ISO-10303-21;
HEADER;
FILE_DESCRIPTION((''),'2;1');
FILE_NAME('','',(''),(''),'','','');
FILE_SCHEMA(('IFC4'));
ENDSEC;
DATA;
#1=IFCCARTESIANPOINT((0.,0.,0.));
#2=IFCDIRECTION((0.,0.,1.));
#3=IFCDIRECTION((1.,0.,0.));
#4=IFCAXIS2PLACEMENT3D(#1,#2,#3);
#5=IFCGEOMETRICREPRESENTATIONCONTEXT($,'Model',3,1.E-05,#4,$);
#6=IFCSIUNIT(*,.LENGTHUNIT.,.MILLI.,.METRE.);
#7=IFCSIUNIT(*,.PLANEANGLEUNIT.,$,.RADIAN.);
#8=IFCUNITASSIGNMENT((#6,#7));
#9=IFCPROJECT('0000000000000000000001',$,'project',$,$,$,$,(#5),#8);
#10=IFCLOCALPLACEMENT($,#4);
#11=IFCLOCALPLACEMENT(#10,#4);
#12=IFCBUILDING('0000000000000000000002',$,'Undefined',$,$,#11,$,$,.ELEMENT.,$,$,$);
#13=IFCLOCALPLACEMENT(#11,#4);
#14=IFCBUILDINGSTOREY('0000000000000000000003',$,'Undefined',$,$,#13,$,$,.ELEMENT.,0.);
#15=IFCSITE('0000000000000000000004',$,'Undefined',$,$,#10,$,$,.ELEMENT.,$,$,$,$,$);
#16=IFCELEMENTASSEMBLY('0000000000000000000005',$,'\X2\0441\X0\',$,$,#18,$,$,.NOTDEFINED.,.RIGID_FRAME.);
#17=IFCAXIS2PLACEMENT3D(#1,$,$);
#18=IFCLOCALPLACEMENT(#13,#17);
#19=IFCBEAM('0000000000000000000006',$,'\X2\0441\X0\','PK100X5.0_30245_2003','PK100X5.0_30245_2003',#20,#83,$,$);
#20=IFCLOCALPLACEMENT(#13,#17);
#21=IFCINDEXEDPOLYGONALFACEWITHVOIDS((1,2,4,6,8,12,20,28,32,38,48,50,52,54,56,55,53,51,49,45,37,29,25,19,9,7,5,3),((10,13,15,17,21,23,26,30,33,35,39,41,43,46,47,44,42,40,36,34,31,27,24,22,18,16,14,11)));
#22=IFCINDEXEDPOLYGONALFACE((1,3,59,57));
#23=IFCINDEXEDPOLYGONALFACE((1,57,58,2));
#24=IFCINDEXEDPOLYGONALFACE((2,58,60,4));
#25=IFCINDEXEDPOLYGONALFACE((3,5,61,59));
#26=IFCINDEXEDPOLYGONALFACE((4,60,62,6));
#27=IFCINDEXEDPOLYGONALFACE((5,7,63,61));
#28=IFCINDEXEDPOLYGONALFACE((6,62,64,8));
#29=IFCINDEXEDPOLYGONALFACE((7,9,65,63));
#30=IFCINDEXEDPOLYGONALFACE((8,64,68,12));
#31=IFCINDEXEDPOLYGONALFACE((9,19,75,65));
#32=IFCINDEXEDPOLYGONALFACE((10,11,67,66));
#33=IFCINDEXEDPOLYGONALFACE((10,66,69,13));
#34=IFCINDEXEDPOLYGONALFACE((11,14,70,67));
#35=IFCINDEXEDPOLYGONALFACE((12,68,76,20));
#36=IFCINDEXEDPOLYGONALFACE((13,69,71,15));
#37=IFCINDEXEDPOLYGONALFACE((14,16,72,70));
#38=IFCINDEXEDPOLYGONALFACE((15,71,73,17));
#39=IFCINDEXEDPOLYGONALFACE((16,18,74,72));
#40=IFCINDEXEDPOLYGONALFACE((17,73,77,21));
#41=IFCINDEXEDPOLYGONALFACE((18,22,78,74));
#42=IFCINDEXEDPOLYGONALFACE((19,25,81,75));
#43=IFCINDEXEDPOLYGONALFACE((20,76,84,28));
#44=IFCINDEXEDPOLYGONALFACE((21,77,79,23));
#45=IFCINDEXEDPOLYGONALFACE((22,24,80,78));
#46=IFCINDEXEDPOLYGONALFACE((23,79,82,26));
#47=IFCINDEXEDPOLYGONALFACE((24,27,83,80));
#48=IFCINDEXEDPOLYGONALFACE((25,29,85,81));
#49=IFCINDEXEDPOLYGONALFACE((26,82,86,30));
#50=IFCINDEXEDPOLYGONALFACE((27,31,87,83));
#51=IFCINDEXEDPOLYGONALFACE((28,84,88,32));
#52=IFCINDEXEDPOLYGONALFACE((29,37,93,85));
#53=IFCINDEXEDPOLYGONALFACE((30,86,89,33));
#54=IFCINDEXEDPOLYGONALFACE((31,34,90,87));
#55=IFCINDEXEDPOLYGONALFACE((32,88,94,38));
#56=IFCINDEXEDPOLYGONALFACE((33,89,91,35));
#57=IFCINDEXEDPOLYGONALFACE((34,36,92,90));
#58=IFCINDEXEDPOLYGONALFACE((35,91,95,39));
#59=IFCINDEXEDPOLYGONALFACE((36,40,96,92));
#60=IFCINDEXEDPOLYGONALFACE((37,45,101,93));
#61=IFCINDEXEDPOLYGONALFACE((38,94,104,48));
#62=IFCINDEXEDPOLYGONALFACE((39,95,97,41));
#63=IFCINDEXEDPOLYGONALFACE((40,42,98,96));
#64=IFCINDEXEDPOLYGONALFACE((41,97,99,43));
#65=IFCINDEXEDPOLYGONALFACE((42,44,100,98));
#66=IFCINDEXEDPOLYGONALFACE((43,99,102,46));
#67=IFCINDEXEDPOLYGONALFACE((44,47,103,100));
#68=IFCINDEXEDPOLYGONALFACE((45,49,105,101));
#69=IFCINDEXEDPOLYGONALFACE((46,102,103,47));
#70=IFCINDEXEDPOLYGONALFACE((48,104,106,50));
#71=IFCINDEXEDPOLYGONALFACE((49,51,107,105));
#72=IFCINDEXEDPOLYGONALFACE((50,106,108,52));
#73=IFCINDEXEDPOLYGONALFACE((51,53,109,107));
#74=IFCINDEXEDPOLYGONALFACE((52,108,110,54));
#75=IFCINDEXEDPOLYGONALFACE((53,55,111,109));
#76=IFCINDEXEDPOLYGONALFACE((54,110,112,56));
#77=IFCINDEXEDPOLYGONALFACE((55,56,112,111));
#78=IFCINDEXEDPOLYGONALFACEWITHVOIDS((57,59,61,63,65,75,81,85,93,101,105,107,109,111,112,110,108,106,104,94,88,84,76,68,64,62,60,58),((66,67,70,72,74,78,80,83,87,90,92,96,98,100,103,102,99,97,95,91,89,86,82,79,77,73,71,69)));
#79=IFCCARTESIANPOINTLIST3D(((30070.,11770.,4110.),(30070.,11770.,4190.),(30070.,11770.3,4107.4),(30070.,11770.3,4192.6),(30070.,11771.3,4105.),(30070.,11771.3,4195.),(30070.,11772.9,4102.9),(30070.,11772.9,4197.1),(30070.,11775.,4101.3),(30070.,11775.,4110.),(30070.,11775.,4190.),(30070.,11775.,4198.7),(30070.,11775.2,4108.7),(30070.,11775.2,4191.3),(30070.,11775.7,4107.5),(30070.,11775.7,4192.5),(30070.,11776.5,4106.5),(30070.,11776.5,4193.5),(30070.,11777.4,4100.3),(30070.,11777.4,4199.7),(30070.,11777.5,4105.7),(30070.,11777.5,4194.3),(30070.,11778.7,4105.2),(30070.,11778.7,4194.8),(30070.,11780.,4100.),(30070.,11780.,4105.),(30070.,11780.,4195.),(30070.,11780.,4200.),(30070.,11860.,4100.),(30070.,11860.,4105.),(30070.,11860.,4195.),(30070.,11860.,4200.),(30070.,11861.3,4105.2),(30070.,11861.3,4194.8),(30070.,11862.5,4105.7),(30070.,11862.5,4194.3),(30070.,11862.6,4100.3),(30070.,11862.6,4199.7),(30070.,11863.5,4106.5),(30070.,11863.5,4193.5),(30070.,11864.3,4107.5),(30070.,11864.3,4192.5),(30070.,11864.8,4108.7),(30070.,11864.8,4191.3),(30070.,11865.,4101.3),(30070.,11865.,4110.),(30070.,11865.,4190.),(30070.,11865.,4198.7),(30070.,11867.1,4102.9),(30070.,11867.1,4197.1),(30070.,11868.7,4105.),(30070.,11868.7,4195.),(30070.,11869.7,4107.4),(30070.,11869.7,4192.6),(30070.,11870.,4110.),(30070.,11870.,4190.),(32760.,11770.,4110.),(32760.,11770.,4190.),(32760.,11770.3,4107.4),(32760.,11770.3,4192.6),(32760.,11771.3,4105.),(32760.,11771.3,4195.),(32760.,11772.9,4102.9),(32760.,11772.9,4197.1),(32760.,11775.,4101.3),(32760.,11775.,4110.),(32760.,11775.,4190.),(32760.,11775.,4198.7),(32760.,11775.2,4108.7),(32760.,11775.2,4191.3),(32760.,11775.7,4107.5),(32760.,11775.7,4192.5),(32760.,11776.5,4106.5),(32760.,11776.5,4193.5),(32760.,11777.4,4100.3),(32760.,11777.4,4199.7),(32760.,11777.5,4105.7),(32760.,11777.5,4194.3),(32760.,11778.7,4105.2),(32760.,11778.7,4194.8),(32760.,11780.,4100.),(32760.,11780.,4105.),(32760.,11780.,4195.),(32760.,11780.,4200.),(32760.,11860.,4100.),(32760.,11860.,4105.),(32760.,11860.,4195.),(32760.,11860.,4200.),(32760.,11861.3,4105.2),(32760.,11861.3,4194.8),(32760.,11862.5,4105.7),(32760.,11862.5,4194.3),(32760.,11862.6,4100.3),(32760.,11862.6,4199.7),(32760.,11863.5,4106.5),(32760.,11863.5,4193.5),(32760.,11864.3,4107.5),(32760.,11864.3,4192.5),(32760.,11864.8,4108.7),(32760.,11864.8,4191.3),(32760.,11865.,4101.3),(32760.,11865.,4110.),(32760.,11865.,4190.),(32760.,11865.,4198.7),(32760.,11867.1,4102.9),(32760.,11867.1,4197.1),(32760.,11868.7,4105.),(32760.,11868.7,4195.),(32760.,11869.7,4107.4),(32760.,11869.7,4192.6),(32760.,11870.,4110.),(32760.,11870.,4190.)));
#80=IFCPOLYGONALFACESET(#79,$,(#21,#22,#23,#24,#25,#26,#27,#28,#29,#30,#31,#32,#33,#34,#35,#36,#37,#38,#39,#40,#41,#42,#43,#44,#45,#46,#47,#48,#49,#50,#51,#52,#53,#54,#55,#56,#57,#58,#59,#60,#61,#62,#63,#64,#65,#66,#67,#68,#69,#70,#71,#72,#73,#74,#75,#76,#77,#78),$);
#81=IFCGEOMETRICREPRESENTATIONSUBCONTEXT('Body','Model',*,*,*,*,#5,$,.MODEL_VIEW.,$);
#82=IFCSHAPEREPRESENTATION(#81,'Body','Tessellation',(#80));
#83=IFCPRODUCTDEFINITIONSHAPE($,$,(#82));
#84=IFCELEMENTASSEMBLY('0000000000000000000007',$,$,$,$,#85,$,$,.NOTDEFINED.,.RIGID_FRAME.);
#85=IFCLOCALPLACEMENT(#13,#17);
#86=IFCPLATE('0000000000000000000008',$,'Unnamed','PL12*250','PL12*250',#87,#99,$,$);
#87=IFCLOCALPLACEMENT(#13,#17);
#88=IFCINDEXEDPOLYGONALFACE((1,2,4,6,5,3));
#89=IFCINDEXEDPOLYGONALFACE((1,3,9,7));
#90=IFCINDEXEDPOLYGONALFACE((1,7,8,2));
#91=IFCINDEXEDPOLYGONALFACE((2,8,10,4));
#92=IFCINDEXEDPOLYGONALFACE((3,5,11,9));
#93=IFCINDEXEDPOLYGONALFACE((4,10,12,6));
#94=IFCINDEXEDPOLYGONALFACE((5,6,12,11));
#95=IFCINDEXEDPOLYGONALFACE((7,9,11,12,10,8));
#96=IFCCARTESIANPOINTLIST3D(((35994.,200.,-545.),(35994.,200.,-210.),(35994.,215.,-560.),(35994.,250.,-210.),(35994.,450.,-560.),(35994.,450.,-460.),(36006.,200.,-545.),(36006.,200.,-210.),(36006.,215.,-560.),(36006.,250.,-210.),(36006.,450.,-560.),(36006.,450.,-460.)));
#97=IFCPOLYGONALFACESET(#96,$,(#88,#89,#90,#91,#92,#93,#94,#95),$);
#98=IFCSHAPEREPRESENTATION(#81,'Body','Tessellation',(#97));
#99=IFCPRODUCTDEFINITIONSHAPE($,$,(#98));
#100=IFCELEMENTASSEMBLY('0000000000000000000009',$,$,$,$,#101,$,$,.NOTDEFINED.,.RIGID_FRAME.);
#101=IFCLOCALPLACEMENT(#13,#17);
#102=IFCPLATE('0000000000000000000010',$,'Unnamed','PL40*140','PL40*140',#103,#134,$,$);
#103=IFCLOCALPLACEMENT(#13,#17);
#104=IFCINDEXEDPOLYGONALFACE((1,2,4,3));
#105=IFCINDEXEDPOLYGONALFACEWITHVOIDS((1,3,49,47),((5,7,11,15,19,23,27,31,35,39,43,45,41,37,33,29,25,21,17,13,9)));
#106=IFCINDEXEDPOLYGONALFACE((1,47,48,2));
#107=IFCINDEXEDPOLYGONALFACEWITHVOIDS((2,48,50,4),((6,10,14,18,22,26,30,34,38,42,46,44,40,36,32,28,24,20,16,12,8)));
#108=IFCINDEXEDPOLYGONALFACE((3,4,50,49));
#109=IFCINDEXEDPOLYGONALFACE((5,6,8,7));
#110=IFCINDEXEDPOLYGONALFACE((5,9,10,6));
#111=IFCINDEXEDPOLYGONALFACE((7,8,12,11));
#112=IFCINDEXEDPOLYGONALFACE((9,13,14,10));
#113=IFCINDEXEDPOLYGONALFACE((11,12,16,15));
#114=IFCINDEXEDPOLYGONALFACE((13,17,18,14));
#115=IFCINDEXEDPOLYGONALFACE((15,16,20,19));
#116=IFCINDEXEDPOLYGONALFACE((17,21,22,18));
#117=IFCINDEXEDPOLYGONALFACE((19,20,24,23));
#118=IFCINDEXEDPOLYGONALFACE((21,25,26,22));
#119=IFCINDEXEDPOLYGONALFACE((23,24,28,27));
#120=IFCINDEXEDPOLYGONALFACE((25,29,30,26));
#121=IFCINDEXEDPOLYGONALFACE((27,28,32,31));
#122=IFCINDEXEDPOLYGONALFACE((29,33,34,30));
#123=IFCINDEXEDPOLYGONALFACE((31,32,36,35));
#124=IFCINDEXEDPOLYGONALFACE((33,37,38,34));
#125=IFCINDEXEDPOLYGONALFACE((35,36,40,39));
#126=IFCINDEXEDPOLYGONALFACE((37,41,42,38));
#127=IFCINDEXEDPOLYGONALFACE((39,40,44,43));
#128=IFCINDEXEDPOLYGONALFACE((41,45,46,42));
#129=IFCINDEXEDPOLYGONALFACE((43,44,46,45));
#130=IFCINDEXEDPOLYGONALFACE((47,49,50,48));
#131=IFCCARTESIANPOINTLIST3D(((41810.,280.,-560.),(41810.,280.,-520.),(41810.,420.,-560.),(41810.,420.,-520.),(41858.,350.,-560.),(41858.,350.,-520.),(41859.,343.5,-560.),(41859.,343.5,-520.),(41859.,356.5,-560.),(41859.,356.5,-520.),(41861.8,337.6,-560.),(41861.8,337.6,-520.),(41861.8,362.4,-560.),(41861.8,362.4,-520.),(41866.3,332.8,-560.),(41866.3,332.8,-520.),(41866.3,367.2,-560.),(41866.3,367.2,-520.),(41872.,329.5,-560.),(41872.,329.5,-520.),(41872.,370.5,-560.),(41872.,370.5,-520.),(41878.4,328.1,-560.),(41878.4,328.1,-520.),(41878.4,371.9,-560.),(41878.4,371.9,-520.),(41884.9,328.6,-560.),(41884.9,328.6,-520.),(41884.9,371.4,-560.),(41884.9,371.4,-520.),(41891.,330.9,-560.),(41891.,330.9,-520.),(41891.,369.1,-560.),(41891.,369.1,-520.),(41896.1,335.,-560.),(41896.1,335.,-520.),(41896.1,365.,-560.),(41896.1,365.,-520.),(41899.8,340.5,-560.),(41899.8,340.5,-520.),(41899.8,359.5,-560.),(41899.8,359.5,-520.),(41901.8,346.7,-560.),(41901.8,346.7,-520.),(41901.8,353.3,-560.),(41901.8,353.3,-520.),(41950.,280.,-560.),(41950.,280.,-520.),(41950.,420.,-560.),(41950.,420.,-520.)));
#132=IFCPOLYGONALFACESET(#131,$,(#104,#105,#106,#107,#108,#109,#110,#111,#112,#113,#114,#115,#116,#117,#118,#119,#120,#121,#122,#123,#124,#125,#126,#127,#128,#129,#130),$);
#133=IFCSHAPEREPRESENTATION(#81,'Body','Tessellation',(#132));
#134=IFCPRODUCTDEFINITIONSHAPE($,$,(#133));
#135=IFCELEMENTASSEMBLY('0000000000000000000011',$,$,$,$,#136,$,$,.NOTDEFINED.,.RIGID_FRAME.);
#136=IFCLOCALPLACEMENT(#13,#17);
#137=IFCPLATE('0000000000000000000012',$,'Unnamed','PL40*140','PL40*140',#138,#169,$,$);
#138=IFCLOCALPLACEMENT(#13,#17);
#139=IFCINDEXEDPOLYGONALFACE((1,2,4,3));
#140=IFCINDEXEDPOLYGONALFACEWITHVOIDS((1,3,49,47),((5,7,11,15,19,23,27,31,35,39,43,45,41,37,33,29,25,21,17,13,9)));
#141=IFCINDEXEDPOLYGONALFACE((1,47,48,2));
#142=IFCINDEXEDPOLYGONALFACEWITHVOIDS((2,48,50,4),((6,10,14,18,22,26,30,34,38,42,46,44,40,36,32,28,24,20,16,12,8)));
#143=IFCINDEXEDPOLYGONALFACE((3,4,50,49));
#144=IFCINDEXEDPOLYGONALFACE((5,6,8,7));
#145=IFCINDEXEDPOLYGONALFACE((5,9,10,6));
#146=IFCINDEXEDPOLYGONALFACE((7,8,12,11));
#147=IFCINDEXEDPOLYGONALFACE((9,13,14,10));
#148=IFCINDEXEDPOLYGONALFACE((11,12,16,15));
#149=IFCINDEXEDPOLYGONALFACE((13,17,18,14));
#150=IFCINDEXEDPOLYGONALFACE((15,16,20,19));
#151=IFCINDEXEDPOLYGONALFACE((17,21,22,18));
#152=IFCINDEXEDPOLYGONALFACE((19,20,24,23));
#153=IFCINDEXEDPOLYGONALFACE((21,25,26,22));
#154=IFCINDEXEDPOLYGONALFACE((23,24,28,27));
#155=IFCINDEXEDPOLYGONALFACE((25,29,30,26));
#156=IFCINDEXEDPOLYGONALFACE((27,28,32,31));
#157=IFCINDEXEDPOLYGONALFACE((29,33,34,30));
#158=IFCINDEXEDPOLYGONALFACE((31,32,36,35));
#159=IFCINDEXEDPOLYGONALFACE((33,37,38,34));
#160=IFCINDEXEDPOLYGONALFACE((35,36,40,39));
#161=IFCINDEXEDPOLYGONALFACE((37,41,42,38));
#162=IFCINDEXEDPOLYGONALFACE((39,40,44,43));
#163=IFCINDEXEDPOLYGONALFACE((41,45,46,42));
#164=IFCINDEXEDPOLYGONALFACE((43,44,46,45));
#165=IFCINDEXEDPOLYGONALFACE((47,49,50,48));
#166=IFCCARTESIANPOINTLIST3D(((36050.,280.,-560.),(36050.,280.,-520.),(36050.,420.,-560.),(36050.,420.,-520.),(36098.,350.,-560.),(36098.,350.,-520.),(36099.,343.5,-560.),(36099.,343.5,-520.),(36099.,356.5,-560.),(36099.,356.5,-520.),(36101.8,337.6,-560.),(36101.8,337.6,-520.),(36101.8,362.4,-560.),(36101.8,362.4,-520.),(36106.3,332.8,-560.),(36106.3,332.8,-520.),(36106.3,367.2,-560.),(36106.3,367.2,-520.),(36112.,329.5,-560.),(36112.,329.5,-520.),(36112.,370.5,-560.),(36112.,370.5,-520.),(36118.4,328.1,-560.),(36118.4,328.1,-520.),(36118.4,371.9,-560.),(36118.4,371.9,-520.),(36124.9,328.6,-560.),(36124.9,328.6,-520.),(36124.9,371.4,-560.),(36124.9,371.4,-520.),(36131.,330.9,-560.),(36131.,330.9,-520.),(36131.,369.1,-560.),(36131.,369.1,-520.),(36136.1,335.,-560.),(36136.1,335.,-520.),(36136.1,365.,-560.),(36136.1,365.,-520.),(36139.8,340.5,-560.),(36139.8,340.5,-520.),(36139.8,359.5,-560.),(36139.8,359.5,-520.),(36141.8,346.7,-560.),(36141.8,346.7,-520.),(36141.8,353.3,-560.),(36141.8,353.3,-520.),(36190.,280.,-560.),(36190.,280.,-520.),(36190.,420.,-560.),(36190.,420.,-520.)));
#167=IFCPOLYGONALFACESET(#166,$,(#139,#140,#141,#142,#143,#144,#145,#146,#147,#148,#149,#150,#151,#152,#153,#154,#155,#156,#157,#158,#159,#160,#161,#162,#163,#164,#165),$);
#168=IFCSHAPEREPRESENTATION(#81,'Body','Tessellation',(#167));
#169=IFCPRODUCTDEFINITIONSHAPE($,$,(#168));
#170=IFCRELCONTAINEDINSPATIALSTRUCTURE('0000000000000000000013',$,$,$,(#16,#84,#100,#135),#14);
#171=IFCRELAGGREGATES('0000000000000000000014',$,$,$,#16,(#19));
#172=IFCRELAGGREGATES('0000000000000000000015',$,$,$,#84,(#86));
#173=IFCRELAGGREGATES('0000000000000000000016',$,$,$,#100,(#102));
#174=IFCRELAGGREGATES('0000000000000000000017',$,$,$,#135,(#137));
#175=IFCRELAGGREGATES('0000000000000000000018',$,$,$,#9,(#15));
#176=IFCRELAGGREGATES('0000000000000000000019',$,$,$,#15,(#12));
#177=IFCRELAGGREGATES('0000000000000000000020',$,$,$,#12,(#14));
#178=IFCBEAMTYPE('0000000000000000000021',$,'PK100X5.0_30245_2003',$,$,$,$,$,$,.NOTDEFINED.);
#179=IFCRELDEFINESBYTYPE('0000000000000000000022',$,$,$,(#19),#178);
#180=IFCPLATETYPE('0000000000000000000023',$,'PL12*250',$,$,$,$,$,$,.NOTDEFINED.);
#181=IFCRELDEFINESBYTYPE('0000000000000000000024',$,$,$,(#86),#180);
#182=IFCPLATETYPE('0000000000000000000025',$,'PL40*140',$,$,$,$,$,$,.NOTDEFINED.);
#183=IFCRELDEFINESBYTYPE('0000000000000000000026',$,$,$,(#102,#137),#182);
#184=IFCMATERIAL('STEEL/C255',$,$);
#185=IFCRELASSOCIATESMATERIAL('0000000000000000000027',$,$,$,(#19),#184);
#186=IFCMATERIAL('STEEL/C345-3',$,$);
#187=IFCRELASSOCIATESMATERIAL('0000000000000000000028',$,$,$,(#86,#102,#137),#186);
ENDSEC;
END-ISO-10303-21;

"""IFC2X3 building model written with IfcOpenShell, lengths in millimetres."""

from ifc_helpers import new_model, si_unit, frame, origin_with_axes, origin_2d_with_axis, place, context, subcontext, project, spatial, polyline, hollow_rectangle, circle, outline, extrude, boolean, material, type_object, element, aggregate, save


model = new_model("IFC2X3")

# Units and contexts
model_context = context("Model", 3, precision=1e-05, world=origin_with_axes())
body_context = subcontext(model_context, "Body", "Model", "MODEL_VIEW")
ifc_project = project(units=[si_unit("LENGTHUNIT", "METRE", prefix="MILLI"), si_unit("PLANEANGLEUNIT", "RADIAN")], contexts=[model_context])

# Site, building, storey
site_placement = place(None, origin_with_axes())
site = spatial("IfcSite", under=ifc_project, at=site_placement, Name="Undefined", CompositionType="ELEMENT")
building_placement = place(site_placement, origin_with_axes())
building = spatial("IfcBuilding", under=site, at=building_placement, Name="Undefined", CompositionType="ELEMENT")
storey_placement = place(building_placement, origin_with_axes())
storey = spatial("IfcBuildingStorey", under=building, at=storey_placement, Name="Undefined", CompositionType="ELEMENT", Elevation=0.0)

# Shared definitions
ifc_material_1 = material(Name="STEEL/C255")
ifc_material_2 = material(Name="STEEL/C345-3")

# Element assembly, beam
assembly_1_placement = place(storey_placement, origin_with_axes())
assembly_1 = element("IfcElementAssembly", 1, at=assembly_1_placement, inside=storey, Name="с", AssemblyPlace="NOTDEFINED", PredefinedType="RIGID_FRAME")
beam_type_1 = type_object("IfcBeamType", Name="PK100X5.0_30245_2003", PredefinedType="NOTDEFINED")
beam_1_placement = place(assembly_1_placement, frame((32760.0, 11820.0, 4150.0), z_axis=(0.0, -1.0, 0.0), x_axis=(-1.0, 0.0, 0.0)))
beam_1 = element("IfcBeam", 2, at=beam_1_placement, type_object=beam_type_1, material=ifc_material_1, Name="с", Description="PK100X5.0_30245_2003", ObjectType="PK100X5.0_30245_2003", context=body_context, shape_type="SweptSolid", body=[
    extrude(hollow_rectangle(XDim=100.0, YDim=100.0, WallThickness=5.0, InnerFilletRadius=5.0, OuterFilletRadius=10.0, at=origin_2d_with_axis()), frame((2690.0, 0.0, 0.0), z_axis=(-1.0, 0.0, 0.0), x_axis=(0.0, -1.0, 0.0)), (0.0, 0.0, 1.0), 2690.0),
])
aggregate(assembly_1, [beam_1])

# Element assemblies, plates
assembly_2_placement = place(storey_placement, origin_with_axes())
assembly_2 = element("IfcElementAssembly", 3, at=assembly_2_placement, inside=storey, AssemblyPlace="NOTDEFINED", PredefinedType="RIGID_FRAME")
plate_type_1 = type_object("IfcPlateType", Name="PL12*250", PredefinedType="NOTDEFINED")
plate_1_placement = place(assembly_2_placement, frame((36000.0, 450.0, -560.0), z_axis=(-1.0, 0.0, 0.0), x_axis=(0.0, -1.0, 0.0)))
plate_1 = element("IfcPlate", 4, at=plate_1_placement, type_object=plate_type_1, material=ifc_material_2, Name="Unnamed", Description="PL12*250", ObjectType="PL12*250", context=body_context, shape_type="SweptSolid", body=[
    extrude(outline(polyline([(0.0, 0.0), (235.0, 0.0), (250.0, 15.0), (250.0, 350.0), (200.0, 350.0), (0.0, 100.0), (0.0, 0.0)])), frame((0.0, 0.0, -6.0), z_axis=(0.0, 0.0, 1.0), x_axis=(1.0, 0.0, 0.0)), (0.0, 0.0, 1.0), 12.0),
])
aggregate(assembly_2, [plate_1])
assembly_3_placement = place(storey_placement, origin_with_axes())
assembly_3 = element("IfcElementAssembly", 5, at=assembly_3_placement, inside=storey, AssemblyPlace="NOTDEFINED", PredefinedType="RIGID_FRAME")
plate_type_2 = type_object("IfcPlateType", Name="PL40*140", PredefinedType="NOTDEFINED")
plate_2_placement = place(assembly_3_placement, frame((41950.0, 280.0, -540.0), z_axis=(0.0, 0.0, 1.0), x_axis=(0.0, 1.0, 0.0)))
plate_2 = element("IfcPlate", 6, at=plate_2_placement, type_object=plate_type_2, material=ifc_material_2, Name="Unnamed", Description="PL40*140", ObjectType="PL40*140", context=body_context, shape_type="CSG", body=[
    boolean("DIFFERENCE", extrude(outline(polyline([(0.0, 0.0), (140.0, 0.0), (140.0, 140.0), (0.0, 140.0), (0.0, 0.0)])), frame((0.0, 0.0, -20.0), z_axis=(0.0, 0.0, 1.0), x_axis=(1.0, 0.0, 0.0)), (0.0, 0.0, 1.0), 40.0), extrude(circle(Radius=22.0, at=origin_2d_with_axis()), frame((70.0, 70.0, 40.0), z_axis=(0.0, 0.0, -1.0), x_axis=(0.0, 1.0, 0.0)), (0.0, 0.0, 1.0), 80.0)),
])
aggregate(assembly_3, [plate_2])
assembly_4_placement = place(storey_placement, origin_with_axes())
assembly_4 = element("IfcElementAssembly", 7, at=assembly_4_placement, inside=storey, AssemblyPlace="NOTDEFINED", PredefinedType="RIGID_FRAME")
plate_3_placement = place(assembly_4_placement, frame((36190.0, 280.0, -540.0), z_axis=(0.0, 0.0, 1.0), x_axis=(0.0, 1.0, 0.0)))
plate_3 = element("IfcPlate", 8, at=plate_3_placement, type_object=plate_type_2, material=ifc_material_2, Name="Unnamed", Description="PL40*140", ObjectType="PL40*140", context=body_context, shape_type="CSG", body=[
    boolean("DIFFERENCE", extrude(outline(polyline([(0.0, 0.0), (140.0, 0.0), (140.0, 140.0), (0.0, 140.0), (0.0, 0.0)])), frame((0.0, 0.0, -20.0), z_axis=(0.0, 0.0, 1.0), x_axis=(1.0, 0.0, 0.0)), (0.0, 0.0, 1.0), 40.0), extrude(circle(Radius=22.0, at=origin_2d_with_axis()), frame((70.0, 70.0, 40.0), z_axis=(0.0, 0.0, -1.0), x_axis=(0.0, 1.0, 0.0)), (0.0, 0.0, 1.0), 80.0)),
])
aggregate(assembly_4, [plate_3])

save(model, "model.ifc")
